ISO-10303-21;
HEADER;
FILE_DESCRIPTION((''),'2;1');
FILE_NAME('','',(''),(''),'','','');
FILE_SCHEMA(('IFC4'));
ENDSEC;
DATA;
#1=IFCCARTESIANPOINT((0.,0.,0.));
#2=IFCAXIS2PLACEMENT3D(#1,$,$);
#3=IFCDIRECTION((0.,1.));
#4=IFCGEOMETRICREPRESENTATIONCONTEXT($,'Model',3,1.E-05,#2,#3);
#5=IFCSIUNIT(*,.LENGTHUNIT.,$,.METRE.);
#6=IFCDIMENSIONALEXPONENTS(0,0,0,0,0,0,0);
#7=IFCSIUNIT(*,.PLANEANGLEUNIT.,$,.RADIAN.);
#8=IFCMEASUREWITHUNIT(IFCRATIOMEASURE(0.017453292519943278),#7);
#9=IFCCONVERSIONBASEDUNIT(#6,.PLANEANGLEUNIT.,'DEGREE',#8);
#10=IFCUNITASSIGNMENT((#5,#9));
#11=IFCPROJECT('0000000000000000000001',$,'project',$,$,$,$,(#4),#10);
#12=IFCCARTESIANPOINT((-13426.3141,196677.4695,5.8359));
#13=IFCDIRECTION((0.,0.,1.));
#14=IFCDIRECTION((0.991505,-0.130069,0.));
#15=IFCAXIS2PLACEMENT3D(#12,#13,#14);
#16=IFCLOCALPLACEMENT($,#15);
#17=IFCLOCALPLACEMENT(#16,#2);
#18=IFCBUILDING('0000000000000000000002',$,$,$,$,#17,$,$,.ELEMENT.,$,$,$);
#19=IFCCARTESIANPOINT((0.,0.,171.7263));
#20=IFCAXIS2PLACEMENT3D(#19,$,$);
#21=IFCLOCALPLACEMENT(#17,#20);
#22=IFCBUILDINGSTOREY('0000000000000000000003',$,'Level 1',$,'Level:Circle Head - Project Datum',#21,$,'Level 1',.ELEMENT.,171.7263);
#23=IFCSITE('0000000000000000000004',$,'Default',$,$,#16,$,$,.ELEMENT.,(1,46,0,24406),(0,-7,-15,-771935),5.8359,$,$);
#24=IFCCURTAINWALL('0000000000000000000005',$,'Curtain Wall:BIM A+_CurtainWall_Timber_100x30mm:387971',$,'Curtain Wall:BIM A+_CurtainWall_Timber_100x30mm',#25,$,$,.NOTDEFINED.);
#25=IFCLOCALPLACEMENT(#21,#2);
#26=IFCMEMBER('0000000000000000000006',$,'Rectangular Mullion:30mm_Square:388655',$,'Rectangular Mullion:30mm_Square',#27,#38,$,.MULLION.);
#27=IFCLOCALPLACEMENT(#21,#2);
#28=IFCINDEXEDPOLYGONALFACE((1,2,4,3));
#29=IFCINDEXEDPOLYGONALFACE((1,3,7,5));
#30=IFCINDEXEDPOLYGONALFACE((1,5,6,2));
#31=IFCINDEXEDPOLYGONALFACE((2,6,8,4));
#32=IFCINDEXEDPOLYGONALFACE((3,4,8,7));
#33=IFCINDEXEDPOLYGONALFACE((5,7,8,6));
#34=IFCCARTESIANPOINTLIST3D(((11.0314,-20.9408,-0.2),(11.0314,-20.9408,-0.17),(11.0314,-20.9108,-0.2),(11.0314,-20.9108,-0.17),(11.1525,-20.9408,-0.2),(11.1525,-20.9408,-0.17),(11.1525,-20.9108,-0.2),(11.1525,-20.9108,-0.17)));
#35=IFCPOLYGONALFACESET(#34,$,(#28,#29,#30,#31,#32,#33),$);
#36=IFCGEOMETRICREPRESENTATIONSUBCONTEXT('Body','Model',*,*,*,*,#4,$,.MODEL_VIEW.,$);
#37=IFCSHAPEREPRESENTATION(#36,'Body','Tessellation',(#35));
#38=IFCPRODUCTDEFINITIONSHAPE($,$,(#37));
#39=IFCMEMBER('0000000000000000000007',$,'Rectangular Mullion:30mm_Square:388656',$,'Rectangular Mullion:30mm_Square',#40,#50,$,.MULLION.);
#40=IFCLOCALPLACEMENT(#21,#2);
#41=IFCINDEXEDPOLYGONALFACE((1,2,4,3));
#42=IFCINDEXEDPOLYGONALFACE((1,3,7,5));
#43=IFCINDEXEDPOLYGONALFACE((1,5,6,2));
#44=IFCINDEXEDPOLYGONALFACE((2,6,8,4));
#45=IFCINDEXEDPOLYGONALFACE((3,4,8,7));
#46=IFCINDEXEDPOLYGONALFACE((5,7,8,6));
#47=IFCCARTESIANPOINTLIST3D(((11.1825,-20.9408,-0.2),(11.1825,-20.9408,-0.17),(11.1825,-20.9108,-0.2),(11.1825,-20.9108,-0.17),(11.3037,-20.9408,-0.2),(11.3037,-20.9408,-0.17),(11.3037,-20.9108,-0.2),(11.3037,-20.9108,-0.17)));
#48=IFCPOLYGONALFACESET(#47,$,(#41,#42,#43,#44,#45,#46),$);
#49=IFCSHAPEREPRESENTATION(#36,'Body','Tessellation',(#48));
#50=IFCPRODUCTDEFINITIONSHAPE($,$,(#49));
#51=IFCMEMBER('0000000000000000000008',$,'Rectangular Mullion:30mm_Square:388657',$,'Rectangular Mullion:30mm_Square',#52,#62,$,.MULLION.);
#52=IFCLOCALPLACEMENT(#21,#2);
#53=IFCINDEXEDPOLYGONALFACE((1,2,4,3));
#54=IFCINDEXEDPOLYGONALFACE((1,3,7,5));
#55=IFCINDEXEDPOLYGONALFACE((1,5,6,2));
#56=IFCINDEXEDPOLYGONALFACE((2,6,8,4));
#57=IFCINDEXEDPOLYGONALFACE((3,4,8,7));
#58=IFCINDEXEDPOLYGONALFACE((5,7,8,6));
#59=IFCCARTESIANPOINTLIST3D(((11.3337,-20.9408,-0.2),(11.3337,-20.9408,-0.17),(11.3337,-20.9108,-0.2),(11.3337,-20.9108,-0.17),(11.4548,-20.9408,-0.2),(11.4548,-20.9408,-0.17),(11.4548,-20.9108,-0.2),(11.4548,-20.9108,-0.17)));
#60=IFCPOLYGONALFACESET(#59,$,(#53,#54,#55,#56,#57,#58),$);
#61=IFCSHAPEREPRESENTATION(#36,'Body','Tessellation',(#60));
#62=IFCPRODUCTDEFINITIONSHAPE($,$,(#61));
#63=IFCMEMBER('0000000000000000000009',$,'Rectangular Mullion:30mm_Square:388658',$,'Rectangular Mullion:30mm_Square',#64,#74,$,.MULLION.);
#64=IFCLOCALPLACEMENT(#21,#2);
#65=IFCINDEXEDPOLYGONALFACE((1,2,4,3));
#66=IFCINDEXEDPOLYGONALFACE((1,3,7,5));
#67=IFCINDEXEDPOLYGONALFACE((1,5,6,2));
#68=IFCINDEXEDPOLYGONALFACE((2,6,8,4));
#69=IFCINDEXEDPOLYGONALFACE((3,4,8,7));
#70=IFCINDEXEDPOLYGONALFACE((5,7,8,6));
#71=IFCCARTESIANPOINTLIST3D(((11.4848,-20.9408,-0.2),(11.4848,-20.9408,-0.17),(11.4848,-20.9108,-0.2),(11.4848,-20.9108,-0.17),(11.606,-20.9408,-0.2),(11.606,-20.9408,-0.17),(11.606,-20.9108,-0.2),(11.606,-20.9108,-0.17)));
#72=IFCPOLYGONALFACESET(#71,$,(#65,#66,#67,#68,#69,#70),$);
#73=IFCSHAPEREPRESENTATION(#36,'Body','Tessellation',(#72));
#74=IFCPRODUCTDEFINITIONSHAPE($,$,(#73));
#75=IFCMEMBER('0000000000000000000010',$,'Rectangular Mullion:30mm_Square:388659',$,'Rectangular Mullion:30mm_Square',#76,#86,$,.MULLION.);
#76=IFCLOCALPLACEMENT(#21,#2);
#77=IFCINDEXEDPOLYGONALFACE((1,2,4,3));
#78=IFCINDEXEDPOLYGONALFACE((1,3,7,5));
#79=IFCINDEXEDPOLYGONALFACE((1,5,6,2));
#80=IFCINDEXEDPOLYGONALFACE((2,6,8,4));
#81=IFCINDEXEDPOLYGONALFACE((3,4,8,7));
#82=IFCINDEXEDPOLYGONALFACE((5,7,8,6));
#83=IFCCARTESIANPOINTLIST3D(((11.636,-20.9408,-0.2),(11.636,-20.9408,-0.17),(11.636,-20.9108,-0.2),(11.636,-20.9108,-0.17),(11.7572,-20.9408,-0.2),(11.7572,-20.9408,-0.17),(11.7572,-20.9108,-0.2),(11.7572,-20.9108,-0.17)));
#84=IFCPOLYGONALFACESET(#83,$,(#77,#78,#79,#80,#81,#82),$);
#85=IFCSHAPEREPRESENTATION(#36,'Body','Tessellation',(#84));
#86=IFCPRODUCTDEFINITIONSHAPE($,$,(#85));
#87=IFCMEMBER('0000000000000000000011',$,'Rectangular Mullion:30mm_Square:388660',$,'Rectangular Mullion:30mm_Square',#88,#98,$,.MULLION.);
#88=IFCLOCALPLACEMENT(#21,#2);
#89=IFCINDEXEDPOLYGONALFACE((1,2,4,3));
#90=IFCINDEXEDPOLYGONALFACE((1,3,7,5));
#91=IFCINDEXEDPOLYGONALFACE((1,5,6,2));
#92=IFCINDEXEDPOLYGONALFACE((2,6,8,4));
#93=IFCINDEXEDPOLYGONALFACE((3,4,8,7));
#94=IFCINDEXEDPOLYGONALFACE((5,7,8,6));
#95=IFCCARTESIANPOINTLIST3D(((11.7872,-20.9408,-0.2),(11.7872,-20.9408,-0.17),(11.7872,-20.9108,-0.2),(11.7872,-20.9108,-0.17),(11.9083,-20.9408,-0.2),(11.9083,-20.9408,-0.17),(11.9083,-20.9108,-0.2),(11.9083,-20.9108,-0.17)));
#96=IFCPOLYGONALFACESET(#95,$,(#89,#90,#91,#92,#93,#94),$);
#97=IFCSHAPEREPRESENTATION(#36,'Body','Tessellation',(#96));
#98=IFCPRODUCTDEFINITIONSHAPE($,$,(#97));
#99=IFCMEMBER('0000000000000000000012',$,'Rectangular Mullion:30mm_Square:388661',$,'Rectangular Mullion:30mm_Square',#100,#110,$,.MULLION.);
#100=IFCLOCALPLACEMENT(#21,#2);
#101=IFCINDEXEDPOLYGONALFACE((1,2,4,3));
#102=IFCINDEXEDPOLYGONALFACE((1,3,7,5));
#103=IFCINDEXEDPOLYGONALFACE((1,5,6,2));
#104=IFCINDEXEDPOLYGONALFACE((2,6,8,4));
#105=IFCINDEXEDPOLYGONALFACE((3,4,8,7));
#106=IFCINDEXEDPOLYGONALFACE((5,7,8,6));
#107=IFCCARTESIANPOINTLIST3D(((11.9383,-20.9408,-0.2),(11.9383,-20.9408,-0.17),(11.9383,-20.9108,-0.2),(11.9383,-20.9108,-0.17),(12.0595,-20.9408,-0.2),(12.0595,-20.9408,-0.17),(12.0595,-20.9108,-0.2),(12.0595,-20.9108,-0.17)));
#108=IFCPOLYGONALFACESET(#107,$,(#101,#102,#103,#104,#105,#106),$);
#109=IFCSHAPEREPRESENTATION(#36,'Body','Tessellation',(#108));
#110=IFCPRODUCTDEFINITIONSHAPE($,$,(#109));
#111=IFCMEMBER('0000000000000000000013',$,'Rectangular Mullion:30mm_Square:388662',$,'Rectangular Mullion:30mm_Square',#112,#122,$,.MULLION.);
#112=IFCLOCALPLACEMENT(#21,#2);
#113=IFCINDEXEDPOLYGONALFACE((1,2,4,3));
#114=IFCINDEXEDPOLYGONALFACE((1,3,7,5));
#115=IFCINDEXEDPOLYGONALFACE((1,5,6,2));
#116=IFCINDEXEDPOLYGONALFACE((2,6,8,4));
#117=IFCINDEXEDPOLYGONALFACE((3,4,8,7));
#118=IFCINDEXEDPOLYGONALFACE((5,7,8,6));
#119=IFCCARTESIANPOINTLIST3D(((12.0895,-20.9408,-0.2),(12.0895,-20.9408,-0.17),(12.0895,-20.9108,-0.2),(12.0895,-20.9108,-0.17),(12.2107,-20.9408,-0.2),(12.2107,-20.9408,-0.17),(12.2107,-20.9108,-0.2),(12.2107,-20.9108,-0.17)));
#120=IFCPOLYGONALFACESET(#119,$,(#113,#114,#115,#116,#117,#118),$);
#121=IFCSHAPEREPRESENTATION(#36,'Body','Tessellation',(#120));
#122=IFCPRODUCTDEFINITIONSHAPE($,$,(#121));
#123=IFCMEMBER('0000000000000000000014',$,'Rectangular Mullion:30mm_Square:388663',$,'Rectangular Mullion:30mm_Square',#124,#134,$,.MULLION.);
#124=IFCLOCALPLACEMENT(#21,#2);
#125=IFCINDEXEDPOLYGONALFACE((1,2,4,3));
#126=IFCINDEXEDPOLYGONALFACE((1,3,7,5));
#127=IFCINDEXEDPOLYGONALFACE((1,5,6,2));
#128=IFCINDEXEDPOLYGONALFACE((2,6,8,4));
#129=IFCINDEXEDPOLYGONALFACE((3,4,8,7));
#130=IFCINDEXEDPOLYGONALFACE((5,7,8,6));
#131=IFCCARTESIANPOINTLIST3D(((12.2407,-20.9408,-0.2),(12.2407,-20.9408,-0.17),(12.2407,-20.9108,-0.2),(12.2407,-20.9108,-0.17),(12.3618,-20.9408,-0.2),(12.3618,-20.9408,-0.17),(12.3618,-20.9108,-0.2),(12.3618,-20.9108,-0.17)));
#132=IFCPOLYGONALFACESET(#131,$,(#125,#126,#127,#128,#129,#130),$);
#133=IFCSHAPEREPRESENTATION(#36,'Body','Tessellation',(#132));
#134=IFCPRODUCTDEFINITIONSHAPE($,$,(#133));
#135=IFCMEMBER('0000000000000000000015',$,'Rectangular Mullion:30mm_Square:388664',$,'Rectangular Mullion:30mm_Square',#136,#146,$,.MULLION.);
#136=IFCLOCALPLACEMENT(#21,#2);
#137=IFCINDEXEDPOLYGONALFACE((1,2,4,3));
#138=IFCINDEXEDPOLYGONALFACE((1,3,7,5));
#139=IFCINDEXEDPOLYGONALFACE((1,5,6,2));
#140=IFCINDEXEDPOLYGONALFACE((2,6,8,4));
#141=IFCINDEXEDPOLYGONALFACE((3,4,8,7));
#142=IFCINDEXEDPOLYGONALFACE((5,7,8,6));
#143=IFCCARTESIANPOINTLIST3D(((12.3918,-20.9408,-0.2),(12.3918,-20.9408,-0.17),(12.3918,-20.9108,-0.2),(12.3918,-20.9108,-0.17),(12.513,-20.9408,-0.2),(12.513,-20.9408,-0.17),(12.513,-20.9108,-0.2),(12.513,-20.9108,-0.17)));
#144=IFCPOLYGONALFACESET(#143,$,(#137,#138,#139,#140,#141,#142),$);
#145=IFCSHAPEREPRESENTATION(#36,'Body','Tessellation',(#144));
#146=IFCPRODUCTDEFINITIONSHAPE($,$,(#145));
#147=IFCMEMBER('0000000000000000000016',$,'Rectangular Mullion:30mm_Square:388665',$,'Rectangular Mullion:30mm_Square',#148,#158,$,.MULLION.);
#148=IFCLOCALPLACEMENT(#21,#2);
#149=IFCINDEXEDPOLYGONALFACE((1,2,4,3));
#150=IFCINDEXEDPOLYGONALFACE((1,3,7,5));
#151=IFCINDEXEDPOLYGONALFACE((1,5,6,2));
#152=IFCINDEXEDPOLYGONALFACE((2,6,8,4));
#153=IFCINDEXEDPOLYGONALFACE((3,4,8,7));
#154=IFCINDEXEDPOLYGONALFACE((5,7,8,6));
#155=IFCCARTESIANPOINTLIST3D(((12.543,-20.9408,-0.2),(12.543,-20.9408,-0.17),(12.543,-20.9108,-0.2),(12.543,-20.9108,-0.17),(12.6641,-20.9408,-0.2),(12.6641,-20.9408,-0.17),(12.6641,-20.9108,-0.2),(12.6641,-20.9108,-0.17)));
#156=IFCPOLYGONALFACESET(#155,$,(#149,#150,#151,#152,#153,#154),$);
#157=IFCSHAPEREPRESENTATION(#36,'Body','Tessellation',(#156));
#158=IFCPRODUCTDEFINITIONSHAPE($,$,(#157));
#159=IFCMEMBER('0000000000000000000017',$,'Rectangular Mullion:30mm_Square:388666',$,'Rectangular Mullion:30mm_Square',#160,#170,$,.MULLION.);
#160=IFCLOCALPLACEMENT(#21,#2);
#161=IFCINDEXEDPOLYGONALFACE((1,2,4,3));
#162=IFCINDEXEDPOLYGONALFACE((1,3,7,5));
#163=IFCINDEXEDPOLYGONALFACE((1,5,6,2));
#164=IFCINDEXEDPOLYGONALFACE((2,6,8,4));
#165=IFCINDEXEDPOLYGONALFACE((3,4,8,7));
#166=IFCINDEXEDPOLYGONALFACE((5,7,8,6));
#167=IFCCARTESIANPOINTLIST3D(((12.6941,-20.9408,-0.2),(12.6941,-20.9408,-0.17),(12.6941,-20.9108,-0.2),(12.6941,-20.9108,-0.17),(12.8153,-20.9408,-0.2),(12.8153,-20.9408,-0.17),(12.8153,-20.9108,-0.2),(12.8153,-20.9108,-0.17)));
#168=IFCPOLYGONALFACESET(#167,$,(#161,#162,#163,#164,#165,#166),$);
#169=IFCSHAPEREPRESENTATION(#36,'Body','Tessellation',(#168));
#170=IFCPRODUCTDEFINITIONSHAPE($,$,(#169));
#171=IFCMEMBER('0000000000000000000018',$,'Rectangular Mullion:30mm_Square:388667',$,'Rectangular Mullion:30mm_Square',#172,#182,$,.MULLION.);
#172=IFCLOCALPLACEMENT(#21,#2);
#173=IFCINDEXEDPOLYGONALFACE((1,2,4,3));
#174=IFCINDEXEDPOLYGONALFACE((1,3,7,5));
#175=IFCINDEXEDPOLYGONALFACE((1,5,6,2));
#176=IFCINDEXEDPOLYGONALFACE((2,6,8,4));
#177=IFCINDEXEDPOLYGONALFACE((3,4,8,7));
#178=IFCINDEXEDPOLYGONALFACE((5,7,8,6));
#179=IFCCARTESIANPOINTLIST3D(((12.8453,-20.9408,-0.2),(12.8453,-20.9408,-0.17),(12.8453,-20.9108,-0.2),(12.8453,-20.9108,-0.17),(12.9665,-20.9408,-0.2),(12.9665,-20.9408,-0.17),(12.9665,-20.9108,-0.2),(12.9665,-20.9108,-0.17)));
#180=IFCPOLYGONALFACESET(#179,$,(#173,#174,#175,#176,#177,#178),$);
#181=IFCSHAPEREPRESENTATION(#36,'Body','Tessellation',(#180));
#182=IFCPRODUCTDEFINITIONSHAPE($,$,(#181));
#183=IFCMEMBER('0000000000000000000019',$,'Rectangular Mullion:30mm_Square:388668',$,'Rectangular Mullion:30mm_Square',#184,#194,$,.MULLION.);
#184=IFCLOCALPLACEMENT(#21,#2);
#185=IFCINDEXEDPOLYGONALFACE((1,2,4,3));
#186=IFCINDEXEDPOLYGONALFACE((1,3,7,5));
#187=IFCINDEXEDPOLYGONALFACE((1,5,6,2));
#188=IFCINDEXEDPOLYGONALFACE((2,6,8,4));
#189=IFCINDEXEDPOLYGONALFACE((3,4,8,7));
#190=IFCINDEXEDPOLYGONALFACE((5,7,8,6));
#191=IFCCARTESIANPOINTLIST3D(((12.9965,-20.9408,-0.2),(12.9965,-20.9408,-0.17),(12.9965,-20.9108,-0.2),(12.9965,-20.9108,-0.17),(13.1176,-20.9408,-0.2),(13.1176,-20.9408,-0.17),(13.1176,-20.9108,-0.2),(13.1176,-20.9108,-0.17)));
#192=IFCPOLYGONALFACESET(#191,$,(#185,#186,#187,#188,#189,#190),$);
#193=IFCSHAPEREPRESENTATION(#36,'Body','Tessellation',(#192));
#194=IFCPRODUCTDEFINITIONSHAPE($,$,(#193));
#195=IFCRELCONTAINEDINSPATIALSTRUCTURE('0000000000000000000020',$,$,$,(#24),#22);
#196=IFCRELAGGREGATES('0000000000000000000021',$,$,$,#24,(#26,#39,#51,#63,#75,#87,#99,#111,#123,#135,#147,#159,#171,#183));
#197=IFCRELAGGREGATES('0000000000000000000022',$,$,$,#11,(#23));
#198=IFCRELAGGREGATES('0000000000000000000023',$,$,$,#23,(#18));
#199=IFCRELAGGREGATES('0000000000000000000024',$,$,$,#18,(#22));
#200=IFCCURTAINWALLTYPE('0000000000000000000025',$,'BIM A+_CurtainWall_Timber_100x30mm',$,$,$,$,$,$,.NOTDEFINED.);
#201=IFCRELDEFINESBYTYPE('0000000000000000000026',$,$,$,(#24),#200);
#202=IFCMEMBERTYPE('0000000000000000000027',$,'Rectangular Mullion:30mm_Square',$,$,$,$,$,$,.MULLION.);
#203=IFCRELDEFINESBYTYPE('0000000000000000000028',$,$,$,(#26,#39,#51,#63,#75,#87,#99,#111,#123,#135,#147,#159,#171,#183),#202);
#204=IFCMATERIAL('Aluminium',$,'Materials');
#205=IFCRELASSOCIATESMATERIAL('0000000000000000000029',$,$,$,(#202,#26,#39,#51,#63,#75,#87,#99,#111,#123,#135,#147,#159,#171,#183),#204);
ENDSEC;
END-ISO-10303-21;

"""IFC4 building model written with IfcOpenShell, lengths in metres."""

from ifc_helpers import new_model, entity, si_unit, converted_unit, direction, frame, origin, place, context, subcontext, project, spatial, indexed_curve, outline, extrude, source, transform, mapped, material, type_object, type_shapes, element, aggregate, save


model = new_model("IFC4")

# Units and contexts
model_context = context("Model", 3, precision=1e-05, world=origin(), true_north=direction((0.0, 1.0)))
body_context = subcontext(model_context, "Body", "Model", "MODEL_VIEW")
ifc_project = project(units=[si_unit("LENGTHUNIT", "METRE"), converted_unit("PLANEANGLEUNIT", "DEGREE", entity("IfcRatioMeasure", 0.017453292519943278), si_unit("PLANEANGLEUNIT", "RADIAN"), dimensions=[0, 0, 0, 0, 0, 0, 0])], contexts=[model_context])

# Site, building, storey
site_placement = place(None, frame((-13426.3141, 196677.4695, 5.8359), z_axis=(0.0, 0.0, 1.0), x_axis=(0.991505, -0.130069, 0.0)))
site = spatial("IfcSite", under=ifc_project, at=site_placement, Name="Default", CompositionType="ELEMENT", RefLatitude=(1, 46, 0, 24406), RefLongitude=(0, -7, -15, -771935), RefElevation=5.8359)
building_placement = place(site_placement, origin())
building = spatial("IfcBuilding", under=site, at=building_placement, CompositionType="ELEMENT")
storey_placement = place(building_placement, frame((0.0, 0.0, 171.7263)))
storey = spatial("IfcBuildingStorey", under=building, at=storey_placement, Name="Level 1", ObjectType="Level:Circle Head - Project Datum", LongName="Level 1", CompositionType="ELEMENT", Elevation=171.7263)

# Curtain wall, members
curtain_wall_type = type_object("IfcCurtainWallType", Name="BIM A+_CurtainWall_Timber_100x30mm", PredefinedType="NOTDEFINED")
curtain_wall_placement = place(storey_placement, frame((0.0, 0.0, -171.7263)))
curtain_wall = element("IfcCurtainWall", 1, at=curtain_wall_placement, inside=storey, type_object=curtain_wall_type, Name="Curtain Wall:BIM A+_CurtainWall_Timber_100x30mm:387971", ObjectType="Curtain Wall:BIM A+_CurtainWall_Timber_100x30mm", PredefinedType="NOTDEFINED")
ifc_material_1 = material(Name="Aluminium", Category="Materials")
member_type_1 = type_object("IfcMemberType", Name="Rectangular Mullion:30mm_Square", PredefinedType="MULLION", material=ifc_material_1)
shared_shape_1 = source(origin(), body_context, "Body", "SweptSolid", [
    extrude(outline(indexed_curve([(-0.015, -0.015), (0.015, -0.015), (0.015, 0.015), (-0.015, 0.015), (-0.015, -0.015)], self_intersect=False)), frame((-0.015, 0.0, -0.1212), z_axis=(0.0, 0.0, 1.0), x_axis=(0.0, -1.0, 0.0)), (0.0, 0.0, 1.0), 0.1212),
])
type_shapes(member_type_1, [shared_shape_1])
member_1_placement = place(curtain_wall_placement, frame((11.0314, -20.9258, 171.5263), z_axis=(-1.0, 0.0, 0.0), x_axis=(0.0, 0.0, -1.0)))
member_1 = element("IfcMember", 2, at=member_1_placement, type_object=member_type_1, material=ifc_material_1, Name="Rectangular Mullion:30mm_Square:388655", ObjectType="Rectangular Mullion:30mm_Square", PredefinedType="MULLION", context=body_context, shape_type="MappedRepresentation", body=[
    mapped(shared_shape_1, transform((0.0, 0.0, 0.0), scale=1.0)),
])
member_2_placement = place(curtain_wall_placement, frame((11.1825, -20.9258, 171.5263), z_axis=(-1.0, 0.0, 0.0), x_axis=(0.0, 0.0, -1.0)))
member_2 = element("IfcMember", 3, at=member_2_placement, type_object=member_type_1, material=ifc_material_1, Name="Rectangular Mullion:30mm_Square:388656", ObjectType="Rectangular Mullion:30mm_Square", PredefinedType="MULLION", context=body_context, shape_type="MappedRepresentation", body=[
    mapped(shared_shape_1, transform((0.0, 0.0, 0.0), scale=1.0)),
])
member_3_placement = place(curtain_wall_placement, frame((11.3337, -20.9258, 171.5263), z_axis=(-1.0, 0.0, 0.0), x_axis=(0.0, 0.0, -1.0)))
member_3 = element("IfcMember", 4, at=member_3_placement, type_object=member_type_1, material=ifc_material_1, Name="Rectangular Mullion:30mm_Square:388657", ObjectType="Rectangular Mullion:30mm_Square", PredefinedType="MULLION", context=body_context, shape_type="MappedRepresentation", body=[
    mapped(shared_shape_1, transform((0.0, 0.0, 0.0), scale=1.0)),
])
member_4_placement = place(curtain_wall_placement, frame((11.4848, -20.9258, 171.5263), z_axis=(-1.0, 0.0, 0.0), x_axis=(0.0, 0.0, -1.0)))
member_4 = element("IfcMember", 5, at=member_4_placement, type_object=member_type_1, material=ifc_material_1, Name="Rectangular Mullion:30mm_Square:388658", ObjectType="Rectangular Mullion:30mm_Square", PredefinedType="MULLION", context=body_context, shape_type="MappedRepresentation", body=[
    mapped(shared_shape_1, transform((0.0, 0.0, 0.0), scale=1.0)),
])
member_5_placement = place(curtain_wall_placement, frame((11.636, -20.9258, 171.5263), z_axis=(-1.0, 0.0, 0.0), x_axis=(0.0, 0.0, -1.0)))
member_5 = element("IfcMember", 6, at=member_5_placement, type_object=member_type_1, material=ifc_material_1, Name="Rectangular Mullion:30mm_Square:388659", ObjectType="Rectangular Mullion:30mm_Square", PredefinedType="MULLION", context=body_context, shape_type="MappedRepresentation", body=[
    mapped(shared_shape_1, transform((0.0, 0.0, 0.0), scale=1.0)),
])
member_6_placement = place(curtain_wall_placement, frame((11.7872, -20.9258, 171.5263), z_axis=(-1.0, 0.0, 0.0), x_axis=(0.0, 0.0, -1.0)))
member_6 = element("IfcMember", 7, at=member_6_placement, type_object=member_type_1, material=ifc_material_1, Name="Rectangular Mullion:30mm_Square:388660", ObjectType="Rectangular Mullion:30mm_Square", PredefinedType="MULLION", context=body_context, shape_type="MappedRepresentation", body=[
    mapped(shared_shape_1, transform((0.0, 0.0, 0.0), scale=1.0)),
])
member_7_placement = place(curtain_wall_placement, frame((11.9383, -20.9258, 171.5263), z_axis=(-1.0, 0.0, 0.0), x_axis=(0.0, 0.0, -1.0)))
member_7 = element("IfcMember", 8, at=member_7_placement, type_object=member_type_1, material=ifc_material_1, Name="Rectangular Mullion:30mm_Square:388661", ObjectType="Rectangular Mullion:30mm_Square", PredefinedType="MULLION", context=body_context, shape_type="MappedRepresentation", body=[
    mapped(shared_shape_1, transform((0.0, 0.0, 0.0), scale=1.0)),
])
member_8_placement = place(curtain_wall_placement, frame((12.0895, -20.9258, 171.5263), z_axis=(-1.0, 0.0, 0.0), x_axis=(0.0, 0.0, -1.0)))
member_8 = element("IfcMember", 9, at=member_8_placement, type_object=member_type_1, material=ifc_material_1, Name="Rectangular Mullion:30mm_Square:388662", ObjectType="Rectangular Mullion:30mm_Square", PredefinedType="MULLION", context=body_context, shape_type="MappedRepresentation", body=[
    mapped(shared_shape_1, transform((0.0, 0.0, 0.0), scale=1.0)),
])
member_9_placement = place(curtain_wall_placement, frame((12.2407, -20.9258, 171.5263), z_axis=(-1.0, 0.0, 0.0), x_axis=(0.0, 0.0, -1.0)))
member_9 = element("IfcMember", 10, at=member_9_placement, type_object=member_type_1, material=ifc_material_1, Name="Rectangular Mullion:30mm_Square:388663", ObjectType="Rectangular Mullion:30mm_Square", PredefinedType="MULLION", context=body_context, shape_type="MappedRepresentation", body=[
    mapped(shared_shape_1, transform((0.0, 0.0, 0.0), scale=1.0)),
])
member_10_placement = place(curtain_wall_placement, frame((12.3918, -20.9258, 171.5263), z_axis=(-1.0, 0.0, 0.0), x_axis=(0.0, 0.0, -1.0)))
member_10 = element("IfcMember", 11, at=member_10_placement, type_object=member_type_1, material=ifc_material_1, Name="Rectangular Mullion:30mm_Square:388664", ObjectType="Rectangular Mullion:30mm_Square", PredefinedType="MULLION", context=body_context, shape_type="MappedRepresentation", body=[
    mapped(shared_shape_1, transform((0.0, 0.0, 0.0), scale=1.0)),
])
member_11_placement = place(curtain_wall_placement, frame((12.543, -20.9258, 171.5263), z_axis=(-1.0, 0.0, 0.0), x_axis=(0.0, 0.0, -1.0)))
member_11 = element("IfcMember", 12, at=member_11_placement, type_object=member_type_1, material=ifc_material_1, Name="Rectangular Mullion:30mm_Square:388665", ObjectType="Rectangular Mullion:30mm_Square", PredefinedType="MULLION", context=body_context, shape_type="MappedRepresentation", body=[
    mapped(shared_shape_1, transform((0.0, 0.0, 0.0), scale=1.0)),
])
member_12_placement = place(curtain_wall_placement, frame((12.6941, -20.9258, 171.5263), z_axis=(-1.0, 0.0, 0.0), x_axis=(0.0, 0.0, -1.0)))
member_12 = element("IfcMember", 13, at=member_12_placement, type_object=member_type_1, material=ifc_material_1, Name="Rectangular Mullion:30mm_Square:388666", ObjectType="Rectangular Mullion:30mm_Square", PredefinedType="MULLION", context=body_context, shape_type="MappedRepresentation", body=[
    mapped(shared_shape_1, transform((0.0, 0.0, 0.0), scale=1.0)),
])
member_13_placement = place(curtain_wall_placement, frame((12.8453, -20.9258, 171.5263), z_axis=(-1.0, 0.0, 0.0), x_axis=(0.0, 0.0, -1.0)))
member_13 = element("IfcMember", 14, at=member_13_placement, type_object=member_type_1, material=ifc_material_1, Name="Rectangular Mullion:30mm_Square:388667", ObjectType="Rectangular Mullion:30mm_Square", PredefinedType="MULLION", context=body_context, shape_type="MappedRepresentation", body=[
    mapped(shared_shape_1, transform((0.0, 0.0, 0.0), scale=1.0)),
])
member_14_placement = place(curtain_wall_placement, frame((12.9965, -20.9258, 171.5263), z_axis=(-1.0, 0.0, 0.0), x_axis=(0.0, 0.0, -1.0)))
member_14 = element("IfcMember", 15, at=member_14_placement, type_object=member_type_1, material=ifc_material_1, Name="Rectangular Mullion:30mm_Square:388668", ObjectType="Rectangular Mullion:30mm_Square", PredefinedType="MULLION", context=body_context, shape_type="MappedRepresentation", body=[
    mapped(shared_shape_1, transform((0.0, 0.0, 0.0), scale=1.0)),
])
aggregate(curtain_wall, [member_1, member_2, member_3, member_4, member_5, member_6, member_7, member_8, member_9, member_10, member_11, member_12, member_13, member_14])

save(model, "model.ifc")
